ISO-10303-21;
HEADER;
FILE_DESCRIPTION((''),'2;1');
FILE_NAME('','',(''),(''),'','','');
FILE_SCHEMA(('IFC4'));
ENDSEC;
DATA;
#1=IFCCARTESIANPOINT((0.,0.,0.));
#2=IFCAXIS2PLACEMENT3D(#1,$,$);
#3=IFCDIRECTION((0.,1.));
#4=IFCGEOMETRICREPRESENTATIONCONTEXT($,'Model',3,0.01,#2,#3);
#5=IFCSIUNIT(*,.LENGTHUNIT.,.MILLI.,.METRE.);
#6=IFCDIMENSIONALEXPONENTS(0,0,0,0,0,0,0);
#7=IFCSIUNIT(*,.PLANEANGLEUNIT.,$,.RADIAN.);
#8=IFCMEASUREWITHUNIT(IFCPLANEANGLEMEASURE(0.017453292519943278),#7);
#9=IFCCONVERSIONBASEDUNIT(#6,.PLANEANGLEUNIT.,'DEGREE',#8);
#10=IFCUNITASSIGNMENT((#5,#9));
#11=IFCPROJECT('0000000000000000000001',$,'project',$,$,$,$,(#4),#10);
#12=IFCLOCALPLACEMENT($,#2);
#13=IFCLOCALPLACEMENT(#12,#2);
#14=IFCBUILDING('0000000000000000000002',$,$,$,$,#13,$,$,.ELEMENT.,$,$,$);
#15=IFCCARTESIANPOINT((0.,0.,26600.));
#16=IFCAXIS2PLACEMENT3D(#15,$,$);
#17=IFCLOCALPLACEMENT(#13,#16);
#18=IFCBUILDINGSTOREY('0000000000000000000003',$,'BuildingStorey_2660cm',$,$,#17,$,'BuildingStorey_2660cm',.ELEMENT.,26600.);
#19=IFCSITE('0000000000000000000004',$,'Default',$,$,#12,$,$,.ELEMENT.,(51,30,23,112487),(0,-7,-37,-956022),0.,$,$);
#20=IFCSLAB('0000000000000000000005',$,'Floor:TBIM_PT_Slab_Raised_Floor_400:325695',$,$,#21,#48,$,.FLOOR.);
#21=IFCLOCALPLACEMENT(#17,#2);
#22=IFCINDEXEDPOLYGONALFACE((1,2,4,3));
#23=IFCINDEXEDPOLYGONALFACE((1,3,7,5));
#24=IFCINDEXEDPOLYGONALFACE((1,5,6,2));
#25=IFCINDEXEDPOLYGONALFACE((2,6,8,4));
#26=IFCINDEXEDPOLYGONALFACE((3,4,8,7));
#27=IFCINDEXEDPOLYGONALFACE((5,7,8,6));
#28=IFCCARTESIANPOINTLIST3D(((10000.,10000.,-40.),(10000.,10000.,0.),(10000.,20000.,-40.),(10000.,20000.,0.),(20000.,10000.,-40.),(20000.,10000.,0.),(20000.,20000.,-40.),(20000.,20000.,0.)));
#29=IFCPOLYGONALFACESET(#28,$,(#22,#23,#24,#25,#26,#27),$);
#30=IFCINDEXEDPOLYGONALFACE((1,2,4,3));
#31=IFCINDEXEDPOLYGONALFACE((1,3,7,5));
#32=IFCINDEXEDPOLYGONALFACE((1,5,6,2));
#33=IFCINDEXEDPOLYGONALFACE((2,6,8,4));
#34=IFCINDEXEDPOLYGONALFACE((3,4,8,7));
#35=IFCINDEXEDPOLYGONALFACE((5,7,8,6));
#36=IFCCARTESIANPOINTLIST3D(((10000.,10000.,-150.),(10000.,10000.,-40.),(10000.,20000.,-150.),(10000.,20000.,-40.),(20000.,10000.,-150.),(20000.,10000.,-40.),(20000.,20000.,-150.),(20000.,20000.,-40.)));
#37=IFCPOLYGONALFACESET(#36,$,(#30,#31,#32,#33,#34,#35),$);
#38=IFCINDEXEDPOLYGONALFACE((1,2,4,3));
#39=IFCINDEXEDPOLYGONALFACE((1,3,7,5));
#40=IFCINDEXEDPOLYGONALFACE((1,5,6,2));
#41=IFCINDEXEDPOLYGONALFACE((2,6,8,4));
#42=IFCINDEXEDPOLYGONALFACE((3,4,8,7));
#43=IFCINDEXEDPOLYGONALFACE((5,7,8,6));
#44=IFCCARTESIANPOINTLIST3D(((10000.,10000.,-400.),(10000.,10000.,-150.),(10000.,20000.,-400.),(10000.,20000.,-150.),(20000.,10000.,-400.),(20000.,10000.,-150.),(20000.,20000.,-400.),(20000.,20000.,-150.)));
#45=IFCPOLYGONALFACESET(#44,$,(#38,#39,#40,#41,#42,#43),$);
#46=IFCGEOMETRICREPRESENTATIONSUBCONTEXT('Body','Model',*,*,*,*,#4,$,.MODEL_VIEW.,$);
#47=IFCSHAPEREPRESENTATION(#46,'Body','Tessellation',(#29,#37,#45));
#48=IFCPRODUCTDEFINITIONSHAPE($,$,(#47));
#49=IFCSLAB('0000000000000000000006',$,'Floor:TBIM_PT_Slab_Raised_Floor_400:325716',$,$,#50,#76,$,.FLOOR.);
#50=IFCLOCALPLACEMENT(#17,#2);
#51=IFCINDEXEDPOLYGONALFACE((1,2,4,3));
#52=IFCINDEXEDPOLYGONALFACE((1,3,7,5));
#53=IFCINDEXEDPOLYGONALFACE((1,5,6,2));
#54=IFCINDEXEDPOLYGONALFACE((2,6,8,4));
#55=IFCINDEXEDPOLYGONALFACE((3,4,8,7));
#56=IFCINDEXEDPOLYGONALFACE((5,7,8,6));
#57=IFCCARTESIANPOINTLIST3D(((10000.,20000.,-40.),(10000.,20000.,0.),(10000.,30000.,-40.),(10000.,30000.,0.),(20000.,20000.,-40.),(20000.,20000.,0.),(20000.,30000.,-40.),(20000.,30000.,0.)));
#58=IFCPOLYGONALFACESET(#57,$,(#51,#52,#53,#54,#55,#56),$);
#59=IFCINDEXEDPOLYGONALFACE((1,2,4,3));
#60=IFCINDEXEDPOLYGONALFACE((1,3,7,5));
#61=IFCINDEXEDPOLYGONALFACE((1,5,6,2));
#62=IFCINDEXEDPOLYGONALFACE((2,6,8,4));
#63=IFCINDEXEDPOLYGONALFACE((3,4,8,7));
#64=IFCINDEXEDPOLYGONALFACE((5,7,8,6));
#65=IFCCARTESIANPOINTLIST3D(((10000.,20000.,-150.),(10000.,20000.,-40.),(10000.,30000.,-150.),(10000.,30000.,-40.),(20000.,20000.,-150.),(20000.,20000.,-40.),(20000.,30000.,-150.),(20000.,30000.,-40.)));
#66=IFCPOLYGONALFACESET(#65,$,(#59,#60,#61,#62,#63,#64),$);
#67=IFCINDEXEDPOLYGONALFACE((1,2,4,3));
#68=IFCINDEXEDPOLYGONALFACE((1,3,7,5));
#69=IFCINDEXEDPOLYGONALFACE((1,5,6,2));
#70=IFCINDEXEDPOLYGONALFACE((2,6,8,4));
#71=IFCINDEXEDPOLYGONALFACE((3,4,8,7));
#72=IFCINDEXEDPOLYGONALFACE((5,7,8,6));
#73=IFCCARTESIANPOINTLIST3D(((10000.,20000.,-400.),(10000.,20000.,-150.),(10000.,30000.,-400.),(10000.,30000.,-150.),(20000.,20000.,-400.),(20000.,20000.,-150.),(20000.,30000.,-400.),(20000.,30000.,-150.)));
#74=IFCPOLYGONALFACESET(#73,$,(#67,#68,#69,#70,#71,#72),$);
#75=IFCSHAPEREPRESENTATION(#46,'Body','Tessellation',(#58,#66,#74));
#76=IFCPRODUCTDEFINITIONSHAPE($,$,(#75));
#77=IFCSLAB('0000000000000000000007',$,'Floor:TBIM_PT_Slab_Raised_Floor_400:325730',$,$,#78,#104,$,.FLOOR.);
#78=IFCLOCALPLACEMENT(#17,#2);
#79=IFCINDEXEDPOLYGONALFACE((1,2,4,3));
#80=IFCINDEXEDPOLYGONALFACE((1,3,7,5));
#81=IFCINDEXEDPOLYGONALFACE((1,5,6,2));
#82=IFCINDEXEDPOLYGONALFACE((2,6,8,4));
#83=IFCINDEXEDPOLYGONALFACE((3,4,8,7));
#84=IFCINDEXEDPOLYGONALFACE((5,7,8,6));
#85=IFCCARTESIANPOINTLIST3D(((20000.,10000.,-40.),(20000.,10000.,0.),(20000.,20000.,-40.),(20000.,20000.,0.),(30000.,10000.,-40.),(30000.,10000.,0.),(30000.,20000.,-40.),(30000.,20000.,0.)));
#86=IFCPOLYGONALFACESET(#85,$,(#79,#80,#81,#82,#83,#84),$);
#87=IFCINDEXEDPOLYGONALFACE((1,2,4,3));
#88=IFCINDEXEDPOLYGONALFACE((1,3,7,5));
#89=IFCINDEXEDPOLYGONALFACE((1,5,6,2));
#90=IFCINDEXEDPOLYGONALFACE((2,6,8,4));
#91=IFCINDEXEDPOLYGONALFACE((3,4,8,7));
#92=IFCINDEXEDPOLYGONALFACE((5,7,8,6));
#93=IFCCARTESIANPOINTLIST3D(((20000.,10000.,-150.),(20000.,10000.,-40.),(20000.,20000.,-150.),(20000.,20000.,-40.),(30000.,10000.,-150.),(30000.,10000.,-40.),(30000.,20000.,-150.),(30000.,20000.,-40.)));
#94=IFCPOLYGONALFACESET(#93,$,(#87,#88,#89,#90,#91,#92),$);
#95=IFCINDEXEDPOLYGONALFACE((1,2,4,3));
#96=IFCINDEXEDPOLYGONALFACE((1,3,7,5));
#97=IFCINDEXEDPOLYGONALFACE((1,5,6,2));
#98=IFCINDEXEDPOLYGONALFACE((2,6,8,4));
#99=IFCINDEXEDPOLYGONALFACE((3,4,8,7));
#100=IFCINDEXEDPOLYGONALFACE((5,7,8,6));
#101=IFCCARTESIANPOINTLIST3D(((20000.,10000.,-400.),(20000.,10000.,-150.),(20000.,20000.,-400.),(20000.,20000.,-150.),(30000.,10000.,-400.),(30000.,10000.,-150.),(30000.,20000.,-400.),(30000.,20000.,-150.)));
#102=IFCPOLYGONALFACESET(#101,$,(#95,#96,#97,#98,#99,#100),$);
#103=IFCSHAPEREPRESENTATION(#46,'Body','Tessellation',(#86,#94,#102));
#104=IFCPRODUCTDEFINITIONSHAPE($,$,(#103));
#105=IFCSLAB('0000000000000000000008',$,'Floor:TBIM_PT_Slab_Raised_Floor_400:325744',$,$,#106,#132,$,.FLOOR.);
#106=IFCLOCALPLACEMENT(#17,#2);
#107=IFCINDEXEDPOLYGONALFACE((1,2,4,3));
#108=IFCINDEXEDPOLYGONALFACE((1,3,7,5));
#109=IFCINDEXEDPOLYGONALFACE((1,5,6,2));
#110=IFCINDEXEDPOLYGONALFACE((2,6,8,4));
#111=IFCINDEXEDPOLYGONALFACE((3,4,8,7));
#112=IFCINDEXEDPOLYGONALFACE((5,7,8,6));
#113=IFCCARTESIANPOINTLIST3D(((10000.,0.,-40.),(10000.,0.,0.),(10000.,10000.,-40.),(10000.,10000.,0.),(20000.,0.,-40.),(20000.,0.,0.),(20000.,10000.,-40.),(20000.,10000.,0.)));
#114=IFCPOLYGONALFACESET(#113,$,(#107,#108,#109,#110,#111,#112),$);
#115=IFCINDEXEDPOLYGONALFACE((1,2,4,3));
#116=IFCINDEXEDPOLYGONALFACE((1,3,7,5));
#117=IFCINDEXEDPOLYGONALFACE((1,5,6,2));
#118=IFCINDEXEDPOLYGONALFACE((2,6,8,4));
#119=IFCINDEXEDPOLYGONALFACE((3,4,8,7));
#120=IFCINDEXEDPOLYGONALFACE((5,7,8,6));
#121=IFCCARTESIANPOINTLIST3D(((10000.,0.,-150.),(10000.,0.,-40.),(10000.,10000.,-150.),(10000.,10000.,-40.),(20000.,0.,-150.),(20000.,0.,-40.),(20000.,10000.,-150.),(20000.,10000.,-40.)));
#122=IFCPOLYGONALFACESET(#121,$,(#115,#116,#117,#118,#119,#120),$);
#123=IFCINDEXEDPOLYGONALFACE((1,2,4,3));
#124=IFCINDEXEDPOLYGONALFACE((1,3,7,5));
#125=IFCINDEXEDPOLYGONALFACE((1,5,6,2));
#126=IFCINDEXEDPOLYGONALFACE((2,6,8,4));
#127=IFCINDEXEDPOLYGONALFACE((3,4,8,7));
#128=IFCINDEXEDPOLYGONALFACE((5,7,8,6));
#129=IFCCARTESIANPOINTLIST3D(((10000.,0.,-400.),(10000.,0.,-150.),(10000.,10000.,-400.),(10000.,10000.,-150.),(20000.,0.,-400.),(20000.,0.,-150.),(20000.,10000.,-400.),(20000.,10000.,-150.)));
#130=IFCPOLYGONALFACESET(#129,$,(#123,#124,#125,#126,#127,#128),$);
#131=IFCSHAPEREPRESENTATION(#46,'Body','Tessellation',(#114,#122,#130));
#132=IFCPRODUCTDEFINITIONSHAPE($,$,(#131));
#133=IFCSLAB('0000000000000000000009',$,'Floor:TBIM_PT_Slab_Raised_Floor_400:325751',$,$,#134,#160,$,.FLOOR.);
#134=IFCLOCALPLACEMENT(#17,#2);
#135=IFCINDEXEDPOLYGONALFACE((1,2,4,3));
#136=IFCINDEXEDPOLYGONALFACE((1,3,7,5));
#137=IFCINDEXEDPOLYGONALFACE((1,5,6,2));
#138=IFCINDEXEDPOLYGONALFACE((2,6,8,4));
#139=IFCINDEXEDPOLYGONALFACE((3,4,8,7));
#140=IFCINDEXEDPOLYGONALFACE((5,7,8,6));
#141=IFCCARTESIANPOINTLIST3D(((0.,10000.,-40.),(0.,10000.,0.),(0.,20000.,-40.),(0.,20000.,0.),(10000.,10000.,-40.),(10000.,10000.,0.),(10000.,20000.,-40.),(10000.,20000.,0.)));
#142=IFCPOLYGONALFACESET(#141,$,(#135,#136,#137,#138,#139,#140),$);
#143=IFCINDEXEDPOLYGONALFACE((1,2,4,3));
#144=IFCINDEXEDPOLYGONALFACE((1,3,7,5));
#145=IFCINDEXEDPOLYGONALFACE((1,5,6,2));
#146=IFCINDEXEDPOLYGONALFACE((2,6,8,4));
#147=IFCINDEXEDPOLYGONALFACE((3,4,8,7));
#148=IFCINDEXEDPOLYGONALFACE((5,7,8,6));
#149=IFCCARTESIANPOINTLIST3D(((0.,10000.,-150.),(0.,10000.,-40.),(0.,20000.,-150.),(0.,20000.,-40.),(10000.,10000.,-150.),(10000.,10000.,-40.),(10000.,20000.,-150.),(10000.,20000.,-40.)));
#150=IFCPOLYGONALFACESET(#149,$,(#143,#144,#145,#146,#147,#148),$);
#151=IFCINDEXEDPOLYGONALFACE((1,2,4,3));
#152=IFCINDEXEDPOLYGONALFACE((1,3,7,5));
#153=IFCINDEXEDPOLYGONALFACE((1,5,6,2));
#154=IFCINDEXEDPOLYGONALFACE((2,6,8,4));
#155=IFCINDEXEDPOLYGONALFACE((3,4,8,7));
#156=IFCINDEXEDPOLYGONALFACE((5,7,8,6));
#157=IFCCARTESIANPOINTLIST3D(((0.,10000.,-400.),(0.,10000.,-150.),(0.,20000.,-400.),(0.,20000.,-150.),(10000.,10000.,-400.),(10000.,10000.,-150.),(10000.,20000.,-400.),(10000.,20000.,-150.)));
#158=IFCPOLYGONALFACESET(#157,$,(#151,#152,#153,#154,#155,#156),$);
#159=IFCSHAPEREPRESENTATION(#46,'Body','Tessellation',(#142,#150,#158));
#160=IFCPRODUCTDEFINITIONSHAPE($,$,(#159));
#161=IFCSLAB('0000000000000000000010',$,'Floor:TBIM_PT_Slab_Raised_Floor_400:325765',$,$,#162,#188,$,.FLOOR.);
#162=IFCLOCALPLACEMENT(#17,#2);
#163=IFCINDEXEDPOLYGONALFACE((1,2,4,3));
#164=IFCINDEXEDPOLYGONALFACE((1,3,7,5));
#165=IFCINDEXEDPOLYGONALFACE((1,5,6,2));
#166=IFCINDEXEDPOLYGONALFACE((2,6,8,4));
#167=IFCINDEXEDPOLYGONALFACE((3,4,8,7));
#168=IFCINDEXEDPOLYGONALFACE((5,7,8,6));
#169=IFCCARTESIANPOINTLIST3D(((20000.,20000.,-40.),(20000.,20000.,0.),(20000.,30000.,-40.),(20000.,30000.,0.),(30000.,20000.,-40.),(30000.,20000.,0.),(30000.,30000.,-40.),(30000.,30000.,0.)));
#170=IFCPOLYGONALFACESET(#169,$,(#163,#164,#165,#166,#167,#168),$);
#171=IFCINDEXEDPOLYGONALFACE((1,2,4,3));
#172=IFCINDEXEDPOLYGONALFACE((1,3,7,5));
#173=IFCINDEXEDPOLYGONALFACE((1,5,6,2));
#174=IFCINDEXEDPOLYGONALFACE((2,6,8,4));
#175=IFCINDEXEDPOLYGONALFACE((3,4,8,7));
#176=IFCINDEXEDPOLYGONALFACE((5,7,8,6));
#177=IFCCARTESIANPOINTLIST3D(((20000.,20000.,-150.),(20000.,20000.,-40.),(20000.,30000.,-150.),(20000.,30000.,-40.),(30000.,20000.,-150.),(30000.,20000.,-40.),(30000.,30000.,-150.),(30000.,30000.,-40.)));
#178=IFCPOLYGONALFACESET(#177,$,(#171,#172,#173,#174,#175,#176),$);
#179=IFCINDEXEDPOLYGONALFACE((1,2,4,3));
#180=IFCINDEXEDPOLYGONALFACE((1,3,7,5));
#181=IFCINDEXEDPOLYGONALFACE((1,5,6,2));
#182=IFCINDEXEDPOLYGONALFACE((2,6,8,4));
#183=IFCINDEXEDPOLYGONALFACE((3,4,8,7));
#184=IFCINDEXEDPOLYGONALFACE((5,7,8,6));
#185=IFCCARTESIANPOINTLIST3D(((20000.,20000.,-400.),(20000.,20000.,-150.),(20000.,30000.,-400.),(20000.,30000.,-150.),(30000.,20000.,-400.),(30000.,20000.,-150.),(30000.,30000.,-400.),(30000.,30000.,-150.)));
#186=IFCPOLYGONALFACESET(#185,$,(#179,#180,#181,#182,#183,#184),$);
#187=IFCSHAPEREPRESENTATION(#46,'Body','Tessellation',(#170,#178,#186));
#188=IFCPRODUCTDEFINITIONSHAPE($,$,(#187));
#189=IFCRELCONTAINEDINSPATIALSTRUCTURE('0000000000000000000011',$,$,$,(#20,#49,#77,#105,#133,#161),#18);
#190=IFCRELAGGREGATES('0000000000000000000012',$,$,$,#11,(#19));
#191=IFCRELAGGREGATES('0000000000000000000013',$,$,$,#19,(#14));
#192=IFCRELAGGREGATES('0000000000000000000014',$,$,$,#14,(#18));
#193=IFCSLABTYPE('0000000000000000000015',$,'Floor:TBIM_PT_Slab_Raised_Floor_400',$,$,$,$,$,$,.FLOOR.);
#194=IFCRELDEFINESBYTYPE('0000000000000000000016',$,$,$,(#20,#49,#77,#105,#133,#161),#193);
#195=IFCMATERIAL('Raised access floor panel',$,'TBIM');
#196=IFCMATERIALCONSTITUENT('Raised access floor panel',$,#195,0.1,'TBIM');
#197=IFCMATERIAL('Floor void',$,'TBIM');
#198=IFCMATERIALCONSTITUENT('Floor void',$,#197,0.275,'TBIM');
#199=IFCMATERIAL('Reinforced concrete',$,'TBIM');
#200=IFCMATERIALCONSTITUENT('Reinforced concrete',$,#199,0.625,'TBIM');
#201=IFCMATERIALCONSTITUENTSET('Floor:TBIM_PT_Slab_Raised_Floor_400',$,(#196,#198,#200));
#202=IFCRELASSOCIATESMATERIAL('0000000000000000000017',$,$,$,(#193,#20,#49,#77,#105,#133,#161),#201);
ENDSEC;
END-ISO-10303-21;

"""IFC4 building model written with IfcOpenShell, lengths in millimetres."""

from ifc_helpers import new_model, entity, si_unit, converted_unit, direction, frame, origin, place, context, subcontext, project, spatial, indexed_curve, outline, extrude, material, constituent, constituent_set, type_object, element, save


model = new_model("IFC4")

# Units and contexts
model_context = context("Model", 3, precision=0.01, world=origin(), true_north=direction((0.0, 1.0)))
body_context = subcontext(model_context, "Body", "Model", "MODEL_VIEW")
ifc_project = project(units=[si_unit("LENGTHUNIT", "METRE", prefix="MILLI"), converted_unit("PLANEANGLEUNIT", "DEGREE", entity("IfcPlaneAngleMeasure", 0.017453292519943278), si_unit("PLANEANGLEUNIT", "RADIAN"), dimensions=[0, 0, 0, 0, 0, 0, 0])], contexts=[model_context])

# Site, building, storey
site_placement = place(None, origin())
site = spatial("IfcSite", under=ifc_project, at=site_placement, Name="Default", CompositionType="ELEMENT", RefLatitude=(51, 30, 23, 112487), RefLongitude=(0, -7, -37, -956022), RefElevation=0.0)
building_placement = place(site_placement, origin())
building = spatial("IfcBuilding", under=site, at=building_placement, CompositionType="ELEMENT")
storey_placement = place(building_placement, frame((0.0, 0.0, 26600.0)))
storey = spatial("IfcBuildingStorey", under=building, at=storey_placement, Name="BuildingStorey_2660cm", LongName="BuildingStorey_2660cm", CompositionType="ELEMENT", Elevation=26600.0)

# Slabs
ifc_material_1 = material(Name="Raised access floor panel", Category="TBIM")
ifc_constituent_1 = constituent(ifc_material_1, Name="Raised access floor panel", Category="TBIM", fraction=0.1)
ifc_material_2 = material(Name="Floor void", Category="TBIM")
ifc_constituent_2 = constituent(ifc_material_2, Name="Floor void", Category="TBIM", fraction=0.275)
ifc_material_3 = material(Name="Reinforced concrete", Category="TBIM")
ifc_constituent_3 = constituent(ifc_material_3, Name="Reinforced concrete", Category="TBIM", fraction=0.625)
ifc_constituent_set_1 = constituent_set(constituents=[ifc_constituent_1, ifc_constituent_2, ifc_constituent_3], Name="Floor:TBIM_PT_Slab_Raised_Floor_400")
slab_type = type_object("IfcSlabType", Name="Floor:TBIM_PT_Slab_Raised_Floor_400", PredefinedType="FLOOR", material=ifc_constituent_set_1)
slab_1_placement = place(storey_placement, origin())
element("IfcSlab", 1, at=slab_1_placement, inside=storey, type_object=slab_type, material=ifc_constituent_set_1, Name="Floor:TBIM_PT_Slab_Raised_Floor_400:325695", PredefinedType="FLOOR", context=body_context, shape_type="SweptSolid", body=[
    extrude(outline(indexed_curve([(-5000.0, -5000.0), (5000.0, -5000.0), (5000.0, 5000.0), (-5000.0, 5000.0), (-5000.0, -5000.0)], self_intersect=False)), frame((15000.0, 15000.0, -40.0), z_axis=(0.0, 0.0, 1.0), x_axis=(-1.0, 0.0, 0.0)), (0.0, 0.0, 1.0), 40.0),
    extrude(outline(indexed_curve([(-5000.0, -5000.0), (5000.0, -5000.0), (5000.0, 5000.0), (-5000.0, 5000.0), (-5000.0, -5000.0)], self_intersect=False)), frame((15000.0, 15000.0, -150.0), z_axis=(0.0, 0.0, 1.0), x_axis=(-1.0, 0.0, 0.0)), (0.0, 0.0, 1.0), 110.0),
    extrude(outline(indexed_curve([(-5000.0, -5000.0), (5000.0, -5000.0), (5000.0, 5000.0), (-5000.0, 5000.0), (-5000.0, -5000.0)], self_intersect=False)), frame((15000.0, 15000.0, -400.0), z_axis=(0.0, 0.0, 1.0), x_axis=(-1.0, 0.0, 0.0)), (0.0, 0.0, 1.0), 250.0),
])
slab_2_placement = place(storey_placement, origin())
element("IfcSlab", 2, at=slab_2_placement, inside=storey, type_object=slab_type, material=ifc_constituent_set_1, Name="Floor:TBIM_PT_Slab_Raised_Floor_400:325716", PredefinedType="FLOOR", context=body_context, shape_type="SweptSolid", body=[
    extrude(outline(indexed_curve([(-5000.0, -5000.0), (5000.0, -5000.0), (5000.0, 5000.0), (-5000.0, 5000.0), (-5000.0, -5000.0)], self_intersect=False)), frame((15000.0, 25000.0, -40.0), z_axis=(0.0, 0.0, 1.0), x_axis=(-1.0, 0.0, 0.0)), (0.0, 0.0, 1.0), 40.0),
    extrude(outline(indexed_curve([(-5000.0, -5000.0), (5000.0, -5000.0), (5000.0, 5000.0), (-5000.0, 5000.0), (-5000.0, -5000.0)], self_intersect=False)), frame((15000.0, 25000.0, -150.0), z_axis=(0.0, 0.0, 1.0), x_axis=(-1.0, 0.0, 0.0)), (0.0, 0.0, 1.0), 110.0),
    extrude(outline(indexed_curve([(-5000.0, -5000.0), (5000.0, -5000.0), (5000.0, 5000.0), (-5000.0, 5000.0), (-5000.0, -5000.0)], self_intersect=False)), frame((15000.0, 25000.0, -400.0), z_axis=(0.0, 0.0, 1.0), x_axis=(-1.0, 0.0, 0.0)), (0.0, 0.0, 1.0), 250.0),
])
slab_3_placement = place(storey_placement, origin())
element("IfcSlab", 3, at=slab_3_placement, inside=storey, type_object=slab_type, material=ifc_constituent_set_1, Name="Floor:TBIM_PT_Slab_Raised_Floor_400:325730", PredefinedType="FLOOR", context=body_context, shape_type="SweptSolid", body=[
    extrude(outline(indexed_curve([(-5000.0, -5000.0), (5000.0, -5000.0), (5000.0, 5000.0), (-5000.0, 5000.0), (-5000.0, -5000.0)], self_intersect=False)), frame((25000.0, 15000.0, -40.0), z_axis=(0.0, 0.0, 1.0), x_axis=(-1.0, 0.0, 0.0)), (0.0, 0.0, 1.0), 40.0),
    extrude(outline(indexed_curve([(-5000.0, -5000.0), (5000.0, -5000.0), (5000.0, 5000.0), (-5000.0, 5000.0), (-5000.0, -5000.0)], self_intersect=False)), frame((25000.0, 15000.0, -150.0), z_axis=(0.0, 0.0, 1.0), x_axis=(-1.0, 0.0, 0.0)), (0.0, 0.0, 1.0), 110.0),
    extrude(outline(indexed_curve([(-5000.0, -5000.0), (5000.0, -5000.0), (5000.0, 5000.0), (-5000.0, 5000.0), (-5000.0, -5000.0)], self_intersect=False)), frame((25000.0, 15000.0, -400.0), z_axis=(0.0, 0.0, 1.0), x_axis=(-1.0, 0.0, 0.0)), (0.0, 0.0, 1.0), 250.0),
])
slab_4_placement = place(storey_placement, origin())
element("IfcSlab", 4, at=slab_4_placement, inside=storey, type_object=slab_type, material=ifc_constituent_set_1, Name="Floor:TBIM_PT_Slab_Raised_Floor_400:325744", PredefinedType="FLOOR", context=body_context, shape_type="SweptSolid", body=[
    extrude(outline(indexed_curve([(-5000.0, -5000.0), (5000.0, -5000.0), (5000.0, 5000.0), (-5000.0, 5000.0), (-5000.0, -5000.0)], self_intersect=False)), frame((15000.0, 5000.0, -40.0), z_axis=(0.0, 0.0, 1.0), x_axis=(0.0, 1.0, 0.0)), (0.0, 0.0, 1.0), 40.0),
    extrude(outline(indexed_curve([(-5000.0, -5000.0), (5000.0, -5000.0), (5000.0, 5000.0), (-5000.0, 5000.0), (-5000.0, -5000.0)], self_intersect=False)), frame((15000.0, 5000.0, -150.0), z_axis=(0.0, 0.0, 1.0), x_axis=(0.0, 1.0, 0.0)), (0.0, 0.0, 1.0), 110.0),
    extrude(outline(indexed_curve([(-5000.0, -5000.0), (5000.0, -5000.0), (5000.0, 5000.0), (-5000.0, 5000.0), (-5000.0, -5000.0)], self_intersect=False)), frame((15000.0, 5000.0, -400.0), z_axis=(0.0, 0.0, 1.0), x_axis=(0.0, 1.0, 0.0)), (0.0, 0.0, 1.0), 250.0),
])
slab_5_placement = place(storey_placement, origin())
element("IfcSlab", 5, at=slab_5_placement, inside=storey, type_object=slab_type, material=ifc_constituent_set_1, Name="Floor:TBIM_PT_Slab_Raised_Floor_400:325751", PredefinedType="FLOOR", context=body_context, shape_type="SweptSolid", body=[
    extrude(outline(indexed_curve([(-5000.0, -5000.0), (5000.0, -5000.0), (5000.0, 5000.0), (-5000.0, 5000.0), (-5000.0, -5000.0)], self_intersect=False)), frame((5000.0, 15000.0, -40.0), z_axis=(0.0, 0.0, 1.0), x_axis=(0.0, 1.0, 0.0)), (0.0, 0.0, 1.0), 40.0),
    extrude(outline(indexed_curve([(-5000.0, -5000.0), (5000.0, -5000.0), (5000.0, 5000.0), (-5000.0, 5000.0), (-5000.0, -5000.0)], self_intersect=False)), frame((5000.0, 15000.0, -150.0), z_axis=(0.0, 0.0, 1.0), x_axis=(0.0, 1.0, 0.0)), (0.0, 0.0, 1.0), 110.0),
    extrude(outline(indexed_curve([(-5000.0, -5000.0), (5000.0, -5000.0), (5000.0, 5000.0), (-5000.0, 5000.0), (-5000.0, -5000.0)], self_intersect=False)), frame((5000.0, 15000.0, -400.0), z_axis=(0.0, 0.0, 1.0), x_axis=(0.0, 1.0, 0.0)), (0.0, 0.0, 1.0), 250.0),
])
slab_6_placement = place(storey_placement, origin())
element("IfcSlab", 6, at=slab_6_placement, inside=storey, type_object=slab_type, material=ifc_constituent_set_1, Name="Floor:TBIM_PT_Slab_Raised_Floor_400:325765", PredefinedType="FLOOR", context=body_context, shape_type="SweptSolid", body=[
    extrude(outline(indexed_curve([(-5000.0, -5000.0), (5000.0, -5000.0), (5000.0, 5000.0), (-5000.0, 5000.0), (-5000.0, -5000.0)], self_intersect=False)), frame((25000.0, 25000.0, -40.0), z_axis=(0.0, 0.0, 1.0), x_axis=(-1.0, 0.0, 0.0)), (0.0, 0.0, 1.0), 40.0),
    extrude(outline(indexed_curve([(-5000.0, -5000.0), (5000.0, -5000.0), (5000.0, 5000.0), (-5000.0, 5000.0), (-5000.0, -5000.0)], self_intersect=False)), frame((25000.0, 25000.0, -150.0), z_axis=(0.0, 0.0, 1.0), x_axis=(-1.0, 0.0, 0.0)), (0.0, 0.0, 1.0), 110.0),
    extrude(outline(indexed_curve([(-5000.0, -5000.0), (5000.0, -5000.0), (5000.0, 5000.0), (-5000.0, 5000.0), (-5000.0, -5000.0)], self_intersect=False)), frame((25000.0, 25000.0, -400.0), z_axis=(0.0, 0.0, 1.0), x_axis=(-1.0, 0.0, 0.0)), (0.0, 0.0, 1.0), 250.0),
])

save(model, "model.ifc")
